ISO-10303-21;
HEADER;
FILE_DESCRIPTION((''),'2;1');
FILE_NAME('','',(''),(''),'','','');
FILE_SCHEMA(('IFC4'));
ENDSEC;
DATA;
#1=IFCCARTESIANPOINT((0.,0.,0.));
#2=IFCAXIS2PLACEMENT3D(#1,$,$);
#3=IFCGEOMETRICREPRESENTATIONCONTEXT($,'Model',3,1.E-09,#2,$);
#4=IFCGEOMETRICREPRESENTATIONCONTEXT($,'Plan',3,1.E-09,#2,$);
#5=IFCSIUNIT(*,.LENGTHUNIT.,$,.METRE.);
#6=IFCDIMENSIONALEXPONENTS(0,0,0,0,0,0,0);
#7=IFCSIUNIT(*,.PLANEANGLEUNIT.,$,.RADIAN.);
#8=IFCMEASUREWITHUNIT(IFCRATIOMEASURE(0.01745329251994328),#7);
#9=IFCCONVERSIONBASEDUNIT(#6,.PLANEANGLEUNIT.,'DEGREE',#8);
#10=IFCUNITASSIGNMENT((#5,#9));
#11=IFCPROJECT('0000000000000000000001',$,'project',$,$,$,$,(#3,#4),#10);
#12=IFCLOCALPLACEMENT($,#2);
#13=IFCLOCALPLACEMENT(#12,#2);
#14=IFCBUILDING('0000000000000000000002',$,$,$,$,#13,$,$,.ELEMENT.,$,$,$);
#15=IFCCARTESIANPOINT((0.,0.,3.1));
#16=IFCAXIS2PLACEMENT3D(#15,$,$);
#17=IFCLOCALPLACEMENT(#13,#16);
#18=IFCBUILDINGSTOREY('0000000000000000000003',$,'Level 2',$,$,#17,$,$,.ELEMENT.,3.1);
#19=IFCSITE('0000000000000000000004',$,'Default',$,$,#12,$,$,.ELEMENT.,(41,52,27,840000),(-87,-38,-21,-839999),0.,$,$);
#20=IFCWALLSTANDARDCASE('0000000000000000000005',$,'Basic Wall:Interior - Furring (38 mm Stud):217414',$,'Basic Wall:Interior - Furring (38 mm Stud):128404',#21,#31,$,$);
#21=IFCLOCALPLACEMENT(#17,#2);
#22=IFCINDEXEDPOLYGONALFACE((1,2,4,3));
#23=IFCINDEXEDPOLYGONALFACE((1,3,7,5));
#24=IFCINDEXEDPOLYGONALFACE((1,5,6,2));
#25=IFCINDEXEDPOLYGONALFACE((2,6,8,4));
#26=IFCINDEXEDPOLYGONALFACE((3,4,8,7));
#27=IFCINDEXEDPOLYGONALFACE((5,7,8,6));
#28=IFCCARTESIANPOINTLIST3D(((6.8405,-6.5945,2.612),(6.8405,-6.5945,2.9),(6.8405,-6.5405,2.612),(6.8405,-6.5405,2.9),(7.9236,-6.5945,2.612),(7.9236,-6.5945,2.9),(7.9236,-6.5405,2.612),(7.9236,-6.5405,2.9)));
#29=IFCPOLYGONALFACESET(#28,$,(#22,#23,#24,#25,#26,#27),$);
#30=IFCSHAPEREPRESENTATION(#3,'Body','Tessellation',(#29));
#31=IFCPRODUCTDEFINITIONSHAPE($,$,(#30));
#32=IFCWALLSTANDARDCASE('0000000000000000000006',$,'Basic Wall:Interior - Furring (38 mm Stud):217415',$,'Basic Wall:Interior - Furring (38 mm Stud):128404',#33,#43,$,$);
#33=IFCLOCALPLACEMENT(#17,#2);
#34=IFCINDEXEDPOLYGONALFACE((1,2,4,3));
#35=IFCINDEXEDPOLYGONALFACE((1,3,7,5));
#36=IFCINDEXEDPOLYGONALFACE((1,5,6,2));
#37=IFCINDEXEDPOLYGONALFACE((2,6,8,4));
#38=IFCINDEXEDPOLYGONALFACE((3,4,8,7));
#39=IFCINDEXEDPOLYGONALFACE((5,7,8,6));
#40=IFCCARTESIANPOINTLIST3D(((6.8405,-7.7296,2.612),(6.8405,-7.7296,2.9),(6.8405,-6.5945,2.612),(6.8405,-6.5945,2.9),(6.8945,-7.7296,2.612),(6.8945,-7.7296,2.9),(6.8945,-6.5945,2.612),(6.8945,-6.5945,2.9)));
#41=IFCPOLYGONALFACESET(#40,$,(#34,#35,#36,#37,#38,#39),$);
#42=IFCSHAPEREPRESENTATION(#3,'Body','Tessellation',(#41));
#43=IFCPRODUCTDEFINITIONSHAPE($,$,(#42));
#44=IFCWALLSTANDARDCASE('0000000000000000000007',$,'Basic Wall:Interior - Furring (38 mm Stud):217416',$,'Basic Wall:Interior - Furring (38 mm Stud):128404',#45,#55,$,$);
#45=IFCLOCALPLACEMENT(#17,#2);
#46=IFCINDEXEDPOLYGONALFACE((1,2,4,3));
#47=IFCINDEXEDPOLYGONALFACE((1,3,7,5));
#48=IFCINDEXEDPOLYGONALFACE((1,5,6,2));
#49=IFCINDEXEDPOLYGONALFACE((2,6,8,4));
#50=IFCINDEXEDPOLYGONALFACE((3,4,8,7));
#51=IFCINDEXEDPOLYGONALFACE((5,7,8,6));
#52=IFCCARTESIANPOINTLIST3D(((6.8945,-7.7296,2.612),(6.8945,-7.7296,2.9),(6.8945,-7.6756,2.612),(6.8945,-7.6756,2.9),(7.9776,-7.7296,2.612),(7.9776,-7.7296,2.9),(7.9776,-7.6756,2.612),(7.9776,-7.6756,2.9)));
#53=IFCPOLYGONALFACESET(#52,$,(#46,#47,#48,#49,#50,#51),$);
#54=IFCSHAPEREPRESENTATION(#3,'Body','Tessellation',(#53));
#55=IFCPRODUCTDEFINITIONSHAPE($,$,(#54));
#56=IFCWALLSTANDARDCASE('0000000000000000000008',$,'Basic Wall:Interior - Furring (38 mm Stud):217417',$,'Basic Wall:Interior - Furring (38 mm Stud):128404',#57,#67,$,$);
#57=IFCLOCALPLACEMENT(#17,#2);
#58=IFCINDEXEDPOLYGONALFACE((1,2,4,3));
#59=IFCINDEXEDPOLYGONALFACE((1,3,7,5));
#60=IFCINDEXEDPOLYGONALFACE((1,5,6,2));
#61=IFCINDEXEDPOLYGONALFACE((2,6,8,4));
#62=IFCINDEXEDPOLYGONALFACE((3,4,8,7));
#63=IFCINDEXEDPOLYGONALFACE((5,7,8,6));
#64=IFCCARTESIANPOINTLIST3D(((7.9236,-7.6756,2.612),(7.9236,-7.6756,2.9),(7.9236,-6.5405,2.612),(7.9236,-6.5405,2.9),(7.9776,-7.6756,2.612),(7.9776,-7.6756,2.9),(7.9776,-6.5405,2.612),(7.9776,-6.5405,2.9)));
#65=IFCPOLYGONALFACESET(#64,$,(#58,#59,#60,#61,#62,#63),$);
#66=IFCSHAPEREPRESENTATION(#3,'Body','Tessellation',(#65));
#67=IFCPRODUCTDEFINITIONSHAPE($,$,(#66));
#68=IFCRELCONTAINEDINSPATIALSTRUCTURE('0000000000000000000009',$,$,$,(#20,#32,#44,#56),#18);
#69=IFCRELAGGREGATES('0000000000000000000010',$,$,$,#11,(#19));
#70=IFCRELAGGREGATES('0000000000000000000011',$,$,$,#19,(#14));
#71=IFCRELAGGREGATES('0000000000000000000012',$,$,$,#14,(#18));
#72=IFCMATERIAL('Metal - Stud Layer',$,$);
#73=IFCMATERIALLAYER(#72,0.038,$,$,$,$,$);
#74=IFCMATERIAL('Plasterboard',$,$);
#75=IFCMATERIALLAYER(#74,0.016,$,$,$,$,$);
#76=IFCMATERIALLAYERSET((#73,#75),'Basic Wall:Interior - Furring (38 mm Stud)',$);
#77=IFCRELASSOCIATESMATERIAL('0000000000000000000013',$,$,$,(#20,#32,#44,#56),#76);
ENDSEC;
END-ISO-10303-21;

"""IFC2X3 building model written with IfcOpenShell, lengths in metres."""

from ifc_helpers import new_model, entity, si_unit, converted_unit, frame, frame_2d, origin, place, context, project, spatial, rectangle, extrude, material, layer, layer_set, layer_usage, element, save


model = new_model("IFC2X3")

# Units and contexts
model_context = context("Model", 3, precision=1e-09, world=origin())
plan_context = context("Plan", 3, precision=1e-09, world=origin())
ifc_project = project(units=[si_unit("LENGTHUNIT", "METRE"), converted_unit("PLANEANGLEUNIT", "DEGREE", entity("IfcRatioMeasure", 0.01745329251994328), si_unit("PLANEANGLEUNIT", "RADIAN"), dimensions=[0, 0, 0, 0, 0, 0, 0])], contexts=[model_context, plan_context])

# Site, building, storey
site_placement = place(None, origin())
site = spatial("IfcSite", under=ifc_project, at=site_placement, Name="Default", CompositionType="ELEMENT", RefLatitude=(41, 52, 27, 840000), RefLongitude=(-87, -38, -21, -839999), RefElevation=0.0)
building_placement = place(site_placement, origin())
building = spatial("IfcBuilding", under=site, at=building_placement, CompositionType="ELEMENT")
storey_placement = place(building_placement, frame((0.0, 0.0, 3.1)))
storey = spatial("IfcBuildingStorey", under=building, at=storey_placement, Name="Level 2", CompositionType="ELEMENT", Elevation=3.1)

# Walls
ifc_material_1 = material(Name="Metal - Stud Layer")
ifc_layer_1 = layer(ifc_material_1, 0.038)
ifc_material_2 = material(Name="Plasterboard")
ifc_layer_2 = layer(ifc_material_2, 0.016)
ifc_layer_set = layer_set([ifc_layer_1, ifc_layer_2], Name="Basic Wall:Interior - Furring (38 mm Stud)")
ifc_layer_usage_1 = layer_usage(ifc_layer_set, "AXIS2", "NEGATIVE", 0.027)
wall_1_placement = place(storey_placement, frame((6.8405, -6.5675, 2.612)))
element("IfcWallStandardCase", 1, at=wall_1_placement, inside=storey, material=ifc_layer_usage_1, Name="Basic Wall:Interior - Furring (38 mm Stud):217414", ObjectType="Basic Wall:Interior - Furring (38 mm Stud):128404", context=model_context, shape_type="SweptSolid", body=[
    extrude(rectangle(XDim=1.0831, YDim=0.054, at=frame_2d((0.5416, 0.0), x_axis=(-1.0, 0.0))), origin(), (0.0, 0.0, 1.0), 0.288),
])
ifc_layer_usage_2 = layer_usage(ifc_layer_set, "AXIS2", "NEGATIVE", 0.027)
wall_2_placement = place(storey_placement, frame((6.8675, -7.7296, 2.612), z_axis=(0.0, 0.0, 1.0), x_axis=(0.0, 1.0, 0.0)))
element("IfcWallStandardCase", 2, at=wall_2_placement, inside=storey, material=ifc_layer_usage_2, Name="Basic Wall:Interior - Furring (38 mm Stud):217415", ObjectType="Basic Wall:Interior - Furring (38 mm Stud):128404", context=model_context, shape_type="SweptSolid", body=[
    extrude(rectangle(XDim=1.1351, YDim=0.054, at=frame_2d((0.5675, 0.0), x_axis=(-1.0, 0.0))), origin(), (0.0, 0.0, 1.0), 0.288),
])
ifc_layer_usage_3 = layer_usage(ifc_layer_set, "AXIS2", "NEGATIVE", 0.027)
wall_3_placement = place(storey_placement, frame((7.9776, -7.7026, 2.612), z_axis=(0.0, 0.0, 1.0), x_axis=(-1.0, 0.0, 0.0)))
element("IfcWallStandardCase", 3, at=wall_3_placement, inside=storey, material=ifc_layer_usage_3, Name="Basic Wall:Interior - Furring (38 mm Stud):217416", ObjectType="Basic Wall:Interior - Furring (38 mm Stud):128404", context=model_context, shape_type="SweptSolid", body=[
    extrude(rectangle(XDim=1.0831, YDim=0.054, at=frame_2d((0.5416, 0.0), x_axis=(-1.0, 0.0))), origin(), (0.0, 0.0, 1.0), 0.288),
])
ifc_layer_usage_4 = layer_usage(ifc_layer_set, "AXIS2", "NEGATIVE", 0.027)
wall_4_placement = place(storey_placement, frame((7.9506, -6.5405, 2.612), z_axis=(0.0, 0.0, 1.0), x_axis=(0.0, -1.0, 0.0)))
element("IfcWallStandardCase", 4, at=wall_4_placement, inside=storey, material=ifc_layer_usage_4, Name="Basic Wall:Interior - Furring (38 mm Stud):217417", ObjectType="Basic Wall:Interior - Furring (38 mm Stud):128404", context=model_context, shape_type="SweptSolid", body=[
    extrude(rectangle(XDim=1.1351, YDim=0.054, at=frame_2d((0.5675, 0.0), x_axis=(-1.0, 0.0))), origin(), (0.0, 0.0, 1.0), 0.288),
])

save(model, "model.ifc")
